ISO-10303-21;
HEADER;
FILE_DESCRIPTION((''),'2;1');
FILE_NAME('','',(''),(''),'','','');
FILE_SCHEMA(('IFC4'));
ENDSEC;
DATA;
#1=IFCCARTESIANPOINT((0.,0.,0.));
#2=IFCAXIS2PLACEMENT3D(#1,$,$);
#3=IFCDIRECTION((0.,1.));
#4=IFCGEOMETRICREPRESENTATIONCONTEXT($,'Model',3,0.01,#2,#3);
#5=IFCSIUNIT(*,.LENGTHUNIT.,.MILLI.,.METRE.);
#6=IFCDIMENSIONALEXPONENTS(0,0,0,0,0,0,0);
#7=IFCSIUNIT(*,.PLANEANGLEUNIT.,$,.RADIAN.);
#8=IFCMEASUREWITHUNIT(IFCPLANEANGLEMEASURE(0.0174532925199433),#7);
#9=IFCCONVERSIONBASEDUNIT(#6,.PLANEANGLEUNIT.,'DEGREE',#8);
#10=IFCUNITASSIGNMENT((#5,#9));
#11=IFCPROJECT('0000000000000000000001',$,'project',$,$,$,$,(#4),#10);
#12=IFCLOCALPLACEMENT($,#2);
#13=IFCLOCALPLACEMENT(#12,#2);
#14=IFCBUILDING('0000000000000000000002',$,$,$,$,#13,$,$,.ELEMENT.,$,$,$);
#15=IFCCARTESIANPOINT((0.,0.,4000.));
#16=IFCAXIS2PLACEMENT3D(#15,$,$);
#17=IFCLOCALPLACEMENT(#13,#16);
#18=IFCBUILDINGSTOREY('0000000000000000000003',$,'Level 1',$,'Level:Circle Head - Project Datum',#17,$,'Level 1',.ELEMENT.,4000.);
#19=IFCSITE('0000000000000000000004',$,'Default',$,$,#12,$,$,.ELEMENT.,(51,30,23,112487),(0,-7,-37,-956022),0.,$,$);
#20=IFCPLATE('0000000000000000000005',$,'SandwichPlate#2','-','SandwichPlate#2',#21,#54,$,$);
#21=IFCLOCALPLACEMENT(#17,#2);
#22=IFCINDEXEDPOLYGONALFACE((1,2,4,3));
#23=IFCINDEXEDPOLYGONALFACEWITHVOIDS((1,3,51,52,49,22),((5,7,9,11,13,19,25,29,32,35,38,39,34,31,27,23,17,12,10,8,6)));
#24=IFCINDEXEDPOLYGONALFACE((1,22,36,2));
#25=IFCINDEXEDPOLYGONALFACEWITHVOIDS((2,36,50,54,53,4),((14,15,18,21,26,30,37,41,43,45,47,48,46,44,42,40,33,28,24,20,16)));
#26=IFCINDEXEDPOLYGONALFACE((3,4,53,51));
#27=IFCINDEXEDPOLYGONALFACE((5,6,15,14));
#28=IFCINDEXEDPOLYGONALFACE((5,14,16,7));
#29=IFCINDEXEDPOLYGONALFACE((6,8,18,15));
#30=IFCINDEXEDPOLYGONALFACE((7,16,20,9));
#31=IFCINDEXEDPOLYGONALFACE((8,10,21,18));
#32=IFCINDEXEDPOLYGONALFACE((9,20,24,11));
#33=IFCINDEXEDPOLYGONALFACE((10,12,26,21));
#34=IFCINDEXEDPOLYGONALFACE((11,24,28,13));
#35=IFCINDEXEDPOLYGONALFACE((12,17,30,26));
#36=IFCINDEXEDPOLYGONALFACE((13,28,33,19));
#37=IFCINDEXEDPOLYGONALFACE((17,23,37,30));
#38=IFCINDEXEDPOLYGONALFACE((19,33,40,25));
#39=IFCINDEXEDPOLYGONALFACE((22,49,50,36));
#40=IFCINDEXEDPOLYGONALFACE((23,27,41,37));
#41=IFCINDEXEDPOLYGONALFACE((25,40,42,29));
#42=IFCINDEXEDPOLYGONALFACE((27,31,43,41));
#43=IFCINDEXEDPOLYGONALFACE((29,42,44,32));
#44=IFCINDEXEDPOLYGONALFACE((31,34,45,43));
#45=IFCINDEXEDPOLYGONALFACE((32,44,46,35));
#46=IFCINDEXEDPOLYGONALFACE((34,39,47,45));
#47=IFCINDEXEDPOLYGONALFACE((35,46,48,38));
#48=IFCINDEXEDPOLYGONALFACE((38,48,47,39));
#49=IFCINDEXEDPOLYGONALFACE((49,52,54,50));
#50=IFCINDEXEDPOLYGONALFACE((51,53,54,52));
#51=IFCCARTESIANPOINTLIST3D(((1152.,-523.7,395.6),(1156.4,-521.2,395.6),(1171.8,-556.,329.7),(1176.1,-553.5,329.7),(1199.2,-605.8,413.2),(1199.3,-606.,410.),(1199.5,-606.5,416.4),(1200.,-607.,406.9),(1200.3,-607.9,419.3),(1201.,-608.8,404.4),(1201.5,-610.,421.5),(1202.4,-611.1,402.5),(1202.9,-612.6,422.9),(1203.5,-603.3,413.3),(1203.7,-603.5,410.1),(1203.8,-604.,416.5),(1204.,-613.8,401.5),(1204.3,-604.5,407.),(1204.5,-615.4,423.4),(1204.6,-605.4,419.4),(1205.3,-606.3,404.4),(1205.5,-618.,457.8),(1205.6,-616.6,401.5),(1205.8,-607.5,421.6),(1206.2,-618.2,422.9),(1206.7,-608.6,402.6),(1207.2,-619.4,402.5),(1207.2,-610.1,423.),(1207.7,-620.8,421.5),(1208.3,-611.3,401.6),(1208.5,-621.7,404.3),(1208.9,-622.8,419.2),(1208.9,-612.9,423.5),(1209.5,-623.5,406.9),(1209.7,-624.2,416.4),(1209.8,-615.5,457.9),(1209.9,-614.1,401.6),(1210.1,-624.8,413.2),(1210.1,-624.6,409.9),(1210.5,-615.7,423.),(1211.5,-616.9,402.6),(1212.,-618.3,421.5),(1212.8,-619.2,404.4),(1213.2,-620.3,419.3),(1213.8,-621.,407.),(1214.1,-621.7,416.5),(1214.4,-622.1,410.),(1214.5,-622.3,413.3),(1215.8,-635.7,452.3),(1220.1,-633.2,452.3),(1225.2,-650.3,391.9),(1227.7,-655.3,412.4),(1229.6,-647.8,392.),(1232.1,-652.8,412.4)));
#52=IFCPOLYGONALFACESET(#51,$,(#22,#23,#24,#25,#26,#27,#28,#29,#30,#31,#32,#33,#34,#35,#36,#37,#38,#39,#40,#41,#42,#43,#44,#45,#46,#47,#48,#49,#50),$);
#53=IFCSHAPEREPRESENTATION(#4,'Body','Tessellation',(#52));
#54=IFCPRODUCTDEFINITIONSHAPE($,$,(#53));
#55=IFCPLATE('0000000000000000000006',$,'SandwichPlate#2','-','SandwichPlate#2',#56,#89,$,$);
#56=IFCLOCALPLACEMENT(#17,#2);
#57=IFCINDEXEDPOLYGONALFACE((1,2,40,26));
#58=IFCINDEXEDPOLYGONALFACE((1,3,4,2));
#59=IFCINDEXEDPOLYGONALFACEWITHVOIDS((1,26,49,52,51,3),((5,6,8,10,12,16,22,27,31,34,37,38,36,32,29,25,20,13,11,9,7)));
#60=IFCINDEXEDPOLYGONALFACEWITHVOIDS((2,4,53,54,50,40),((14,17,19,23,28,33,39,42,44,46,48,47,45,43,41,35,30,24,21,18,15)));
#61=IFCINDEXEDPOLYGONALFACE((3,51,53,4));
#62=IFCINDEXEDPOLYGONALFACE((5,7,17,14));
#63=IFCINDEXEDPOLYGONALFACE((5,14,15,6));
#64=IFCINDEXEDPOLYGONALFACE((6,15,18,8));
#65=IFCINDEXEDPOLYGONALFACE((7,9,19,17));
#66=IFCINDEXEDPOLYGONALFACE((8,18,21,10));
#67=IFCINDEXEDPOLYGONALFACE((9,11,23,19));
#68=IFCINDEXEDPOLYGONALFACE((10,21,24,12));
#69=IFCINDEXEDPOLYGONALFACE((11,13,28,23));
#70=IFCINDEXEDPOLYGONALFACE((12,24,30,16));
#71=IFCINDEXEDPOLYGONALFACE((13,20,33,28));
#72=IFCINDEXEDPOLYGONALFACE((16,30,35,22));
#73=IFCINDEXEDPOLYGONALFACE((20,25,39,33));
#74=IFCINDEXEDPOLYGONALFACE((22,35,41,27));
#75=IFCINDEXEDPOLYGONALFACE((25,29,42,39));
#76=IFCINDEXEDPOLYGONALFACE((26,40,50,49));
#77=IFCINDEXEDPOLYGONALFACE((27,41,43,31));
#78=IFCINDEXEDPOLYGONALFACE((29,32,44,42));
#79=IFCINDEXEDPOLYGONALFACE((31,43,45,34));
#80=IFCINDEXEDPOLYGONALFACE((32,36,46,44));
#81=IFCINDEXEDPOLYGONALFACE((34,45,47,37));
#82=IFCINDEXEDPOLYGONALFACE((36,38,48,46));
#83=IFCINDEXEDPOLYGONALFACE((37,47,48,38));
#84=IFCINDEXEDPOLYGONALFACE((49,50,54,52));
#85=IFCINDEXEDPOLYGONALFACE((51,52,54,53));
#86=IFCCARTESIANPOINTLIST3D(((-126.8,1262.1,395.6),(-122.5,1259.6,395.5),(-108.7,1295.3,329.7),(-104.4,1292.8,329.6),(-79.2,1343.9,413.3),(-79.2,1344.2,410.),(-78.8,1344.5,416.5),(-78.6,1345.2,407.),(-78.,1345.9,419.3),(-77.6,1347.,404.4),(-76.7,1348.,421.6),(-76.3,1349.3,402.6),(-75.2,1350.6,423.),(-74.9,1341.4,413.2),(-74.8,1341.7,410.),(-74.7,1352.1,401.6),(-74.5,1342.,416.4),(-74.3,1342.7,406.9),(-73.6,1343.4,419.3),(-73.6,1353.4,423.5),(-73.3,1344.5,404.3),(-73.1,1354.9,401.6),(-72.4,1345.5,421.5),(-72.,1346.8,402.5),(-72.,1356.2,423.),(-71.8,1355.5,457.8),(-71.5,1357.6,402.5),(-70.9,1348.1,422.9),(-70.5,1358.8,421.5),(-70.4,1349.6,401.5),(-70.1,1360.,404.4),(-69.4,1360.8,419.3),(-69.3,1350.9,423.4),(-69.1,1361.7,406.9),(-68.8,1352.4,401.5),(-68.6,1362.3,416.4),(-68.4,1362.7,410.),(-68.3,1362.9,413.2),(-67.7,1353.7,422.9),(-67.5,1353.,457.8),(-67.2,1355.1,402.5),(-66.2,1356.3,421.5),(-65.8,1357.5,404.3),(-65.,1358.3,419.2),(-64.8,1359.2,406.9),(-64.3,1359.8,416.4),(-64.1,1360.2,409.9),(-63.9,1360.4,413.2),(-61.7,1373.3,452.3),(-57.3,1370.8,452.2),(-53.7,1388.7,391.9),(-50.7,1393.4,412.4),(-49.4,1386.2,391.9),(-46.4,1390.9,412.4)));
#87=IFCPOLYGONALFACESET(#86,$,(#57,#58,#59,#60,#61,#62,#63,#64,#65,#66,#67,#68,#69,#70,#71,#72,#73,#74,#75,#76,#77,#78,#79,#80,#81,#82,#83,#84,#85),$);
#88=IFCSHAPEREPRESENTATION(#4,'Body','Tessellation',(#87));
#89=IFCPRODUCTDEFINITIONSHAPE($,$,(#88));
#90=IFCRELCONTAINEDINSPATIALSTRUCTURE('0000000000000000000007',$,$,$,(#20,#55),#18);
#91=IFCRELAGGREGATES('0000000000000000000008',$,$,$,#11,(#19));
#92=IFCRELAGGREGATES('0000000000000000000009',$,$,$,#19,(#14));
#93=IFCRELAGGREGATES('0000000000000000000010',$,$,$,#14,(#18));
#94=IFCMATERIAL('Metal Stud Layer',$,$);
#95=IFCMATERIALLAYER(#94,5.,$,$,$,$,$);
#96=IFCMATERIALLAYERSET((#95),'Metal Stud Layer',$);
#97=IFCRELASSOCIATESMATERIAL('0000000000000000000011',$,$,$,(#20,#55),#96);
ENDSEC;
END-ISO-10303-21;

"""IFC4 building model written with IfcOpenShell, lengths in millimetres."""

from ifc_helpers import new_model, entity, si_unit, converted_unit, direction, frame, origin, origin_with_axes, origin_2d_with_axis, place, context, project, spatial, polyline, circle, outline, extrude, material, layer, layer_set, element, save


model = new_model("IFC4")

# Units and contexts
model_context = context("Model", 3, precision=0.01, world=origin(), true_north=direction((0.0, 1.0)))
ifc_project = project(units=[si_unit("LENGTHUNIT", "METRE", prefix="MILLI"), converted_unit("PLANEANGLEUNIT", "DEGREE", entity("IfcPlaneAngleMeasure", 0.0174532925199433), si_unit("PLANEANGLEUNIT", "RADIAN"), dimensions=[0, 0, 0, 0, 0, 0, 0])], contexts=[model_context])

# Site, building, storey
site_placement = place(None, origin())
site = spatial("IfcSite", under=ifc_project, at=site_placement, Name="Default", CompositionType="ELEMENT", RefLatitude=(51, 30, 23, 112487), RefLongitude=(0, -7, -37, -956022), RefElevation=0.0)
building_placement = place(site_placement, origin())
building = spatial("IfcBuilding", under=site, at=building_placement, CompositionType="ELEMENT")
storey_placement = place(building_placement, frame((0.0, 0.0, 4000.0)))
storey = spatial("IfcBuildingStorey", under=building, at=storey_placement, Name="Level 1", ObjectType="Level:Circle Head - Project Datum", LongName="Level 1", CompositionType="ELEMENT", Elevation=4000.0)

# Plates, openings
ifc_material_1 = material(Name="Metal Stud Layer")
ifc_layer = layer(ifc_material_1, 5.0)
ifc_layer_set = layer_set([ifc_layer], Name="Metal Stud Layer")
plate_1_placement = place(storey_placement, frame((1236.0, -659.2, 399.4), z_axis=(-0.865935, -0.499948, -0.014432), x_axis=(-0.259821, 0.424992, 0.867107)))
plate_1 = element("IfcPlate", 1, at=plate_1_placement, inside=storey, material=ifc_layer_set, Name="SandwichPlate#2", Description="-", ObjectType="SandwichPlate#2", context=model_context, shape_type="SweptSolid", body=[
    extrude(outline(polyline([(0.0, 0.0), (76.0, 0.0), (76.0, 140.0), (0.0, 140.0), (0.0, 0.0)])), origin_with_axes(), (0.0, 0.0, 1.0), 5.0),
])
opening_1_placement = place(plate_1_placement, frame((0.0, 0.0, 0.0), z_axis=(0.0, 0.0, 1.0), x_axis=(1.0, 0.0, 0.0)))
element("IfcOpeningElement", 2, at=opening_1_placement, cuts=plate_1, ObjectType="Opening", context=model_context, shape_type="SweptSolid", body=[
    extrude(outline(polyline([(0.0, 0.0), (15.0, 0.0), (0.0, 15.0), (0.0, 0.0)])), origin(), (0.0, 0.0, 1.0), 5.0),
])
opening_2_placement = place(plate_1_placement, frame((0.0, 0.0, 0.0), z_axis=(0.0, 0.0, 1.0), x_axis=(1.0, 0.0, 0.0)))
element("IfcOpeningElement", 3, at=opening_2_placement, cuts=plate_1, ObjectType="Opening", context=model_context, shape_type="SweptSolid", body=[
    extrude(outline(polyline([(76.0, 0.0), (76.0, 15.0), (61.0, 0.0), (76.0, 0.0)])), origin(), (0.0, 0.0, 1.0), 5.0),
])
opening_3_placement = place(plate_1_placement, frame((38.0, 40.0, -0.5), z_axis=(0.0, 0.0, 1.0), x_axis=(0.0, 1.0, 0.0)))
element("IfcOpeningElement", 4, at=opening_3_placement, cuts=plate_1, ObjectType="Opening", context=model_context, shape_type="SweptSolid", body=[
    extrude(circle(Radius=11.0, at=origin_2d_with_axis()), origin(), (0.0, 0.0, 1.0), 6.0),
])
plate_2_placement = place(storey_placement, frame((-47.1, 1400.0, 399.4), z_axis=(0.865935, -0.499948, -0.014432), x_axis=(-0.238139, -0.437501, 0.867112)))
plate_2 = element("IfcPlate", 5, at=plate_2_placement, inside=storey, material=ifc_layer_set, Name="SandwichPlate#2", Description="-", ObjectType="SandwichPlate#2", context=model_context, shape_type="SweptSolid", body=[
    extrude(outline(polyline([(0.0, 0.0), (76.0, 0.0), (76.0, 140.0), (0.0, 140.0), (0.0, 0.0)])), origin_with_axes(), (0.0, 0.0, 1.0), 5.0),
])
opening_4_placement = place(plate_2_placement, frame((0.0, 0.0, 0.0), z_axis=(0.0, 0.0, 1.0), x_axis=(1.0, 0.0, 0.0)))
element("IfcOpeningElement", 6, at=opening_4_placement, cuts=plate_2, ObjectType="Opening", context=model_context, shape_type="SweptSolid", body=[
    extrude(outline(polyline([(0.0, 0.0), (15.0, 0.0), (0.0, 15.0), (0.0, 0.0)])), origin(), (0.0, 0.0, 1.0), 5.0),
])
opening_5_placement = place(plate_2_placement, frame((0.0, 0.0, 0.0), z_axis=(0.0, 0.0, 1.0), x_axis=(1.0, 0.0, 0.0)))
element("IfcOpeningElement", 7, at=opening_5_placement, cuts=plate_2, ObjectType="Opening", context=model_context, shape_type="SweptSolid", body=[
    extrude(outline(polyline([(76.0, 0.0), (76.0, 15.0), (61.0, 0.0), (76.0, 0.0)])), origin(), (0.0, 0.0, 1.0), 5.0),
])
opening_6_placement = place(plate_2_placement, frame((38.0, 40.0, -0.5), z_axis=(0.0, 0.0, 1.0), x_axis=(0.0, 1.0, 0.0)))
element("IfcOpeningElement", 8, at=opening_6_placement, cuts=plate_2, ObjectType="Opening", context=model_context, shape_type="SweptSolid", body=[
    extrude(circle(Radius=11.0, at=origin_2d_with_axis()), origin(), (0.0, 0.0, 1.0), 6.0),
])

save(model, "model.ifc")
